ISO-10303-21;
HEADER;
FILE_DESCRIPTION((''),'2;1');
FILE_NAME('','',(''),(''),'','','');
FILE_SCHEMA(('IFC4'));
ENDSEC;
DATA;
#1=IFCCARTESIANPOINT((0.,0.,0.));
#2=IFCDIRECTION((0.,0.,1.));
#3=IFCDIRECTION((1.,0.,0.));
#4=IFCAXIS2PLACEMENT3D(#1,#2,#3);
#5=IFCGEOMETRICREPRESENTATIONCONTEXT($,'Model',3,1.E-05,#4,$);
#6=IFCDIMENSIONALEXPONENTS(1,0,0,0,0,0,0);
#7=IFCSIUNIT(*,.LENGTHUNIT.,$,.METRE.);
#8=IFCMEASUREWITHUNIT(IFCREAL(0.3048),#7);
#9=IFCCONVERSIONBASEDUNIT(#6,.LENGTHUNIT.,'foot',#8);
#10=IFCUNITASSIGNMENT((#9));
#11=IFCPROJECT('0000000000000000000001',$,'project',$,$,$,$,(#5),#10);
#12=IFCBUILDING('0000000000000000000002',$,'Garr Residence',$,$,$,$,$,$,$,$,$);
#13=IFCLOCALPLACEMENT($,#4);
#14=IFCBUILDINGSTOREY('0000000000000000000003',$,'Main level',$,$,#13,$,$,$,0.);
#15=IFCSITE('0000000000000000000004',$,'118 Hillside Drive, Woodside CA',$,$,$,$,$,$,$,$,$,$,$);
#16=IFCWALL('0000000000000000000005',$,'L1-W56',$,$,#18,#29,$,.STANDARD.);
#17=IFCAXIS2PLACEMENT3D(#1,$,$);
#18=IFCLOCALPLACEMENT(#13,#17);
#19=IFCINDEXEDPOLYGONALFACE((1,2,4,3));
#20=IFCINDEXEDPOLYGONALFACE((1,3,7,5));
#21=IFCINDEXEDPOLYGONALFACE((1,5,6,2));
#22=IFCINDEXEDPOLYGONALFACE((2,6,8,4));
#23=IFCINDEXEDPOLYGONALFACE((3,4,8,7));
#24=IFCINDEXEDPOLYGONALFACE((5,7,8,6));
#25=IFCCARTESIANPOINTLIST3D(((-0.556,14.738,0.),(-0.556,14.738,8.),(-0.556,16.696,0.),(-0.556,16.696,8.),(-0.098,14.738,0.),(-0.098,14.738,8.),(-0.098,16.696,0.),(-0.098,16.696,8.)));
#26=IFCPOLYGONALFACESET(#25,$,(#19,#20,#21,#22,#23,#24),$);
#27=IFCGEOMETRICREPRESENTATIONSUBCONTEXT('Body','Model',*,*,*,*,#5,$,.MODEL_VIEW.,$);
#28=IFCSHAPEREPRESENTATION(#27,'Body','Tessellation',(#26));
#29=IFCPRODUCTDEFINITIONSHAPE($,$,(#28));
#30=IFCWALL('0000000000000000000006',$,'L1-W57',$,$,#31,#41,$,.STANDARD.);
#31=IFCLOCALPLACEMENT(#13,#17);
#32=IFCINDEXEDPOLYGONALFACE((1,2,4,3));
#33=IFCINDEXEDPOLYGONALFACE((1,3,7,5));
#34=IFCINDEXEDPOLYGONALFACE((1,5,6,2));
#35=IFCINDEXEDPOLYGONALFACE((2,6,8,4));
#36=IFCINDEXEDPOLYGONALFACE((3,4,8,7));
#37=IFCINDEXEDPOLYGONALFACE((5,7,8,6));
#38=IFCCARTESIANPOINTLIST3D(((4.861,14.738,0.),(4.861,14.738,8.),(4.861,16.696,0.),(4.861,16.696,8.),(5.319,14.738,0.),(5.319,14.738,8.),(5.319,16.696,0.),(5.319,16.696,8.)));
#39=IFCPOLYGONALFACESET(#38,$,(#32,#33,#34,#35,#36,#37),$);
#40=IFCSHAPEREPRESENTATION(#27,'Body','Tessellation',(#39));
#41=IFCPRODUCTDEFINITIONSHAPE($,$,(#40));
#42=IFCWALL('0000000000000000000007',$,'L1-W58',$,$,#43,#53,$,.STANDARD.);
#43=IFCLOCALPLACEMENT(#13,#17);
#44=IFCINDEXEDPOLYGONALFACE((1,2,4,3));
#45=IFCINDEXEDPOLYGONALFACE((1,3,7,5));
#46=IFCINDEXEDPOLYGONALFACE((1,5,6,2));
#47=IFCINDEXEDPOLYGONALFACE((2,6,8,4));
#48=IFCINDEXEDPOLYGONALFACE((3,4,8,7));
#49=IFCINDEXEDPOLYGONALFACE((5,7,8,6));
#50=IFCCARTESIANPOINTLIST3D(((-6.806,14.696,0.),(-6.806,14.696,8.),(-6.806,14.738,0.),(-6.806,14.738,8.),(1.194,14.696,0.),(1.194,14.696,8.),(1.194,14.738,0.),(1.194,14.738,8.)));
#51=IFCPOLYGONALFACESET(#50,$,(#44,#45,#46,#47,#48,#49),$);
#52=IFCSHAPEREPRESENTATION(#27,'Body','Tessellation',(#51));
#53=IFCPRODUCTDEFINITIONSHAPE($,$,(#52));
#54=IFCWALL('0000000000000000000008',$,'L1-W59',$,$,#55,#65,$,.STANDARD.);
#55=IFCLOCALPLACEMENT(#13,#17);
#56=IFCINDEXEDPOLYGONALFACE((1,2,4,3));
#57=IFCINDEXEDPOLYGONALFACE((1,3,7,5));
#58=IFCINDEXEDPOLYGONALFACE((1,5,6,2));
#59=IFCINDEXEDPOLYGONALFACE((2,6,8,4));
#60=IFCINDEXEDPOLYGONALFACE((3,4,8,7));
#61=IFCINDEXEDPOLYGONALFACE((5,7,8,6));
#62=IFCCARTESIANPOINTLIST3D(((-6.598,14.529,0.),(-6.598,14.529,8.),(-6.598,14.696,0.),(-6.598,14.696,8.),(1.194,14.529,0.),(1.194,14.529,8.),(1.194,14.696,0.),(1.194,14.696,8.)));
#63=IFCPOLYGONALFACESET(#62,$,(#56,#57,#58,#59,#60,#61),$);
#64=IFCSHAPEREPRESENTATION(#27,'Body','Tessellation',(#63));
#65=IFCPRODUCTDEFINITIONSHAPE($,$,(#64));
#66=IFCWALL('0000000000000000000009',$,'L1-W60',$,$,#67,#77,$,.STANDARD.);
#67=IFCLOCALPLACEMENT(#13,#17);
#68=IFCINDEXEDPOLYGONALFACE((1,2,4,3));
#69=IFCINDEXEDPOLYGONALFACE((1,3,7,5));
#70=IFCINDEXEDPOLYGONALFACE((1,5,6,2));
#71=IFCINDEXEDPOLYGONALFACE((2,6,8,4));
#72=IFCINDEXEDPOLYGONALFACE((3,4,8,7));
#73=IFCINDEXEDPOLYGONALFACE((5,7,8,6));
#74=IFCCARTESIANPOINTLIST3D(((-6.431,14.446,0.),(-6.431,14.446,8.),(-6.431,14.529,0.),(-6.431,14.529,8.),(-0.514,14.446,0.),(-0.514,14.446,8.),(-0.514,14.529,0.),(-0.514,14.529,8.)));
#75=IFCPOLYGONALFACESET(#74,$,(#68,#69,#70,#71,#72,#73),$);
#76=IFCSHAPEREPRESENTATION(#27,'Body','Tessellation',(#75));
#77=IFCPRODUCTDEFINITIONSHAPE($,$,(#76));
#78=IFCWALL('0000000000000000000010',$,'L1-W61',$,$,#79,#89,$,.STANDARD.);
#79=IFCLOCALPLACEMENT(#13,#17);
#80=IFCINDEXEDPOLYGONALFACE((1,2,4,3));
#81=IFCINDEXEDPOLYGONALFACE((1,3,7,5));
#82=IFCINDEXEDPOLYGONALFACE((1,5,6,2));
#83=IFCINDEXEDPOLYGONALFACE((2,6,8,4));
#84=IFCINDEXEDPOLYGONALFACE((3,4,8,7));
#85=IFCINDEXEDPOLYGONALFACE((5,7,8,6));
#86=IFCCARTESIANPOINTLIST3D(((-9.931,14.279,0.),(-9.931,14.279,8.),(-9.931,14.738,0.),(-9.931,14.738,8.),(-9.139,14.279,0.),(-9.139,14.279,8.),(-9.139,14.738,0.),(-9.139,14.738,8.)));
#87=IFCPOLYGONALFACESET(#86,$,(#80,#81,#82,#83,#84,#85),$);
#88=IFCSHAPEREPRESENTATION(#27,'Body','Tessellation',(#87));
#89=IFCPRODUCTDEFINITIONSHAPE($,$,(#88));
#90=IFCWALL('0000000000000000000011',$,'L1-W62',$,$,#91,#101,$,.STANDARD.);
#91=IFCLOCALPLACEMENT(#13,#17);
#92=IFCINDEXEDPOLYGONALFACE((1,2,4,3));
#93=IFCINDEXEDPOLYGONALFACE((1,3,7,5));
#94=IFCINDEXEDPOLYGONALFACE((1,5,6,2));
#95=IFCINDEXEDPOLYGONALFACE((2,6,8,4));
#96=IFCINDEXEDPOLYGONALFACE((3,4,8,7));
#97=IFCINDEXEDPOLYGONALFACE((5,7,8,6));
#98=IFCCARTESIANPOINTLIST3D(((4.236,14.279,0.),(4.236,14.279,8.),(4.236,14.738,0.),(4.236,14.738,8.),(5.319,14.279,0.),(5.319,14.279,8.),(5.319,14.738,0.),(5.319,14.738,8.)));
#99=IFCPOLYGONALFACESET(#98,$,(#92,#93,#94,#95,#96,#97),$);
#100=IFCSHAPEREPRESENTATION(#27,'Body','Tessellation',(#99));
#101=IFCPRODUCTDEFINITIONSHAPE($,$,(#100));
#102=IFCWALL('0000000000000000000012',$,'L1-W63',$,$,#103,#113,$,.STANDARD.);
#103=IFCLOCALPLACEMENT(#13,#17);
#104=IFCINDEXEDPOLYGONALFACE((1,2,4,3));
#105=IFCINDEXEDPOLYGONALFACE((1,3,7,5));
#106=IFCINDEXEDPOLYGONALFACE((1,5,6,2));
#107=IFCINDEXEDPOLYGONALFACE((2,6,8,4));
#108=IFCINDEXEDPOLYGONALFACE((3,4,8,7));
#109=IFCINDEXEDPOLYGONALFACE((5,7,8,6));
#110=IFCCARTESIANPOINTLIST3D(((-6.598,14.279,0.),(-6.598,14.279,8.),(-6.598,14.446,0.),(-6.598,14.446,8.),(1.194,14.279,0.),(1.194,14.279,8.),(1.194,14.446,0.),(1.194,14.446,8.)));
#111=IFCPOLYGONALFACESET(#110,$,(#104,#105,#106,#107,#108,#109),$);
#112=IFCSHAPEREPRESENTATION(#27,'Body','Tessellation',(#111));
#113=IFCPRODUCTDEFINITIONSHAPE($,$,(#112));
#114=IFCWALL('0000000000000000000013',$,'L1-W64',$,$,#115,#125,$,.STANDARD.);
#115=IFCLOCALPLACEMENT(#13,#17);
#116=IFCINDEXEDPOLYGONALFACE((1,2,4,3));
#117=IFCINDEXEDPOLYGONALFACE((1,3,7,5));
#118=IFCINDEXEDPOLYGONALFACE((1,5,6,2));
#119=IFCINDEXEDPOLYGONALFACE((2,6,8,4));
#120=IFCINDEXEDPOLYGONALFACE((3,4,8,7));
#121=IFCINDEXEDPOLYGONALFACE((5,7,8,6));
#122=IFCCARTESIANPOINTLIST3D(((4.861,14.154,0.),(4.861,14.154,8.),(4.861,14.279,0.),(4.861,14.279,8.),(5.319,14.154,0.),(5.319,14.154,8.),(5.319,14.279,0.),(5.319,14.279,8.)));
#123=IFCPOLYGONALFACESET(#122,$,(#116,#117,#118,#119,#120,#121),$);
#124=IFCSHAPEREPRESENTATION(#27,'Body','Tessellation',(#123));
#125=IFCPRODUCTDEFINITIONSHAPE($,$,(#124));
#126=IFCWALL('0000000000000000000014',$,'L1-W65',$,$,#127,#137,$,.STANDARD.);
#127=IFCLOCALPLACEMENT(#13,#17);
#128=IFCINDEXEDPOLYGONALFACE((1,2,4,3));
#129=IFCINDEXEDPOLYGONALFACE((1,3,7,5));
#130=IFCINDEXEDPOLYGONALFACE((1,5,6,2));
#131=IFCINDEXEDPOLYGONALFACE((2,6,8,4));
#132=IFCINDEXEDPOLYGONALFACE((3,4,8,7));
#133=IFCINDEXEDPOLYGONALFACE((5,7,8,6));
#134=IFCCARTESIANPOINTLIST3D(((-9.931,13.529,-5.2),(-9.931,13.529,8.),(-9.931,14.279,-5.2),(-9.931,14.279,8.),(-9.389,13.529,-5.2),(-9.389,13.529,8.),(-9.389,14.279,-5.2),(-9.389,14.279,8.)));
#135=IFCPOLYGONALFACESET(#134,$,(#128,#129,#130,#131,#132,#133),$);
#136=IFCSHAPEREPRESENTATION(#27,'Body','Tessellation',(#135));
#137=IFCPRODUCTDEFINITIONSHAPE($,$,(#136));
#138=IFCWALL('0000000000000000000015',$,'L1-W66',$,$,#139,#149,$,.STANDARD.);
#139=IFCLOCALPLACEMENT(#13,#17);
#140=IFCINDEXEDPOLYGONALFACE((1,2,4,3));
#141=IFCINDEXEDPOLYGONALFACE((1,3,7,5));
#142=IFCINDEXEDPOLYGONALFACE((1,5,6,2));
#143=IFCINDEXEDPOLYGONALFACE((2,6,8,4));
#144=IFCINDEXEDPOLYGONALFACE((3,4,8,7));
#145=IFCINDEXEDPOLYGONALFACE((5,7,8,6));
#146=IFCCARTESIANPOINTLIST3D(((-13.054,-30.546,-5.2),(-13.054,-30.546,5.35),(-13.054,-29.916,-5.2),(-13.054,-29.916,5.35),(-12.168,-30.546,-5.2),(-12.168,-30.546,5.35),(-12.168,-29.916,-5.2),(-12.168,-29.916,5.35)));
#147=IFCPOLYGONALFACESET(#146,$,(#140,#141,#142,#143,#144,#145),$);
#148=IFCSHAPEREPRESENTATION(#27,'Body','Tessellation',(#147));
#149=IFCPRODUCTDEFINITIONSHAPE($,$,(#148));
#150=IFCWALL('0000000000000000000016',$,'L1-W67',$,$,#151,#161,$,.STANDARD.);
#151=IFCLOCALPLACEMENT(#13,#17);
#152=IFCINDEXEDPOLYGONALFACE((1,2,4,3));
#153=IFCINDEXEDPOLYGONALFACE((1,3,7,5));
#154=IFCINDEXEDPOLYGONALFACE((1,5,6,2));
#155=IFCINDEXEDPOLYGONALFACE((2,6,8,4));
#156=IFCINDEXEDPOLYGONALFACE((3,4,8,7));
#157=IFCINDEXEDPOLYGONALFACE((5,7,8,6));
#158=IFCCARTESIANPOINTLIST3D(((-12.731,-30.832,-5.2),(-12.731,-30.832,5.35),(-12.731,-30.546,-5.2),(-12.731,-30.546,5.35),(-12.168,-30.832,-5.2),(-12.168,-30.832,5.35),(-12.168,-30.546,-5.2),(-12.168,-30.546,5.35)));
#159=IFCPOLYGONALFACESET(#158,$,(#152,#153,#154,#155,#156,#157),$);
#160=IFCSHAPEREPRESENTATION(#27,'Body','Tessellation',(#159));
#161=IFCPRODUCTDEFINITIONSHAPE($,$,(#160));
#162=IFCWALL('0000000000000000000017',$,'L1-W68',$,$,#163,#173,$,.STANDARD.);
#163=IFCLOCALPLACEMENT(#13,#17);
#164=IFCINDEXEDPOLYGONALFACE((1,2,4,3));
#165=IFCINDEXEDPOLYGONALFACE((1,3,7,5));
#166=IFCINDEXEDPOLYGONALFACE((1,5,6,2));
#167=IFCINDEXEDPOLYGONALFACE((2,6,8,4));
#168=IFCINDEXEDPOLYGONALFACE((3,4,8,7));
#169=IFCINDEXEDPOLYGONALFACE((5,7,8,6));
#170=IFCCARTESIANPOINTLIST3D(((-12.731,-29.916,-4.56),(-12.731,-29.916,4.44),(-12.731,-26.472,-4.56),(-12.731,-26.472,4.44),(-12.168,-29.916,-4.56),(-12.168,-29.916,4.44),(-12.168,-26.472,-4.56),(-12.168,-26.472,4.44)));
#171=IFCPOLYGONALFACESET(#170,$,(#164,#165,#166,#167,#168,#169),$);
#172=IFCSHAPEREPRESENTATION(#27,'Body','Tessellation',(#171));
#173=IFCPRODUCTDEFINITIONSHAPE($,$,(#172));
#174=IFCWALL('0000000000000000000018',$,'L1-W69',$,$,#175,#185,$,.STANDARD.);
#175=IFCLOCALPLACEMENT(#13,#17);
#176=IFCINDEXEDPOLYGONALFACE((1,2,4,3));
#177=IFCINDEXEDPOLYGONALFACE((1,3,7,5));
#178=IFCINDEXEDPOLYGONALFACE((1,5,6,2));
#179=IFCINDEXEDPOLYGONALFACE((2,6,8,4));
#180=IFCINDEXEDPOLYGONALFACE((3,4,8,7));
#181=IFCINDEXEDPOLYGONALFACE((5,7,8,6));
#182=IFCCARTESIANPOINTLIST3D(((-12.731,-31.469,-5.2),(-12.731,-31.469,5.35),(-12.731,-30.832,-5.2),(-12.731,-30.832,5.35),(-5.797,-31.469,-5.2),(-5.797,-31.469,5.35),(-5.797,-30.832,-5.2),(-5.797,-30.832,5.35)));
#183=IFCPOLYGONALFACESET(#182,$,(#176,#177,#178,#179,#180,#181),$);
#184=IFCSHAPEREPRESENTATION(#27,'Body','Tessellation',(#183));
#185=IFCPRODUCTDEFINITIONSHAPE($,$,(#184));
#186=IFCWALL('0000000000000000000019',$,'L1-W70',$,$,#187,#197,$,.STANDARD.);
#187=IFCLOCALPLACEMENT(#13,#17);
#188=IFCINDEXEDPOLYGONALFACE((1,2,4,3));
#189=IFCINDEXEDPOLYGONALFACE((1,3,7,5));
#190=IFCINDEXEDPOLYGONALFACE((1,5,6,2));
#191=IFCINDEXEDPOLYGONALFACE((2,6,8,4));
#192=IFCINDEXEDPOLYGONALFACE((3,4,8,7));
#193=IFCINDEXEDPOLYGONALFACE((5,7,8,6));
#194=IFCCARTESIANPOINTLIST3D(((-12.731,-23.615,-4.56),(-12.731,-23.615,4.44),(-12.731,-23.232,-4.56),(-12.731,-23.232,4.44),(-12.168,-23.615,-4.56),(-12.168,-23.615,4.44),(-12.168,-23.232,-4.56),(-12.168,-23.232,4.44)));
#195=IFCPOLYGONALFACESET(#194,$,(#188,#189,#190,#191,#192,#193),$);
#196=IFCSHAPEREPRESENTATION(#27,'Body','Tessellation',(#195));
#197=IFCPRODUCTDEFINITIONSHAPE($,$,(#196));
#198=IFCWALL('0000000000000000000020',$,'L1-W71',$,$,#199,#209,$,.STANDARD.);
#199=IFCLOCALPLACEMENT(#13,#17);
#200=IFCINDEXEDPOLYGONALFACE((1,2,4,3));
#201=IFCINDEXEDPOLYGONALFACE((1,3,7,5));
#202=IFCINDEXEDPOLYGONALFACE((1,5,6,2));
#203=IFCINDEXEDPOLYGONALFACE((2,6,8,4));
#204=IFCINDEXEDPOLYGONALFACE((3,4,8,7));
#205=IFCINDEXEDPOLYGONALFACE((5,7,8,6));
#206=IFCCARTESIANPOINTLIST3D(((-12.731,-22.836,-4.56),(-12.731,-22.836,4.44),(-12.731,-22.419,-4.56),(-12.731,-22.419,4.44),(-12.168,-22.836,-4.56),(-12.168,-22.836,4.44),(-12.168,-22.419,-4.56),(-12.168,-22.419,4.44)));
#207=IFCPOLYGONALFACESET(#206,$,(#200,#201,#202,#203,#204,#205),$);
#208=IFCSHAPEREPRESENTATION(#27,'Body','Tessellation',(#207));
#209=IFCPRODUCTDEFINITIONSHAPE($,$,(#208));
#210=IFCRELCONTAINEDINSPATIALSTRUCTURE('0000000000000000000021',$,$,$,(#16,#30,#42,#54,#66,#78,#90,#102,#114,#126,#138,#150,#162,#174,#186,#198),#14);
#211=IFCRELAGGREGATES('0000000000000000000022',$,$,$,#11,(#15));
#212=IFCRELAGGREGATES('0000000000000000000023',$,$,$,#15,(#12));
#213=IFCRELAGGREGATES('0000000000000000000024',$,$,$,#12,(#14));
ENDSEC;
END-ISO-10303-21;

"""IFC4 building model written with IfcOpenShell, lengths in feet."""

from ifc_helpers import new_model, entity, si_unit, converted_unit, frame, origin, origin_with_axes, place, context, subcontext, project, spatial, polyline, outline, extrude, element, save


model = new_model("IFC4")

# Units and contexts
model_context = context("Model", 3, precision=1e-05, world=origin_with_axes())
body_context = subcontext(model_context, "Body", "Model", "MODEL_VIEW")
ifc_project = project(units=[converted_unit("LENGTHUNIT", "foot", entity("IfcReal", 0.3048), si_unit("LENGTHUNIT", "METRE"), dimensions=[1, 0, 0, 0, 0, 0, 0])], contexts=[model_context])

# Site, building, storey
site = spatial("IfcSite", under=ifc_project, Name="118 Hillside Drive, Woodside CA")
building = spatial("IfcBuilding", under=site, Name="Garr Residence")
storey_placement = place(None, origin_with_axes())
storey = spatial("IfcBuildingStorey", under=building, at=storey_placement, Name="Main level", Elevation=0.0)

# Walls
wall_1_placement = place(storey_placement, origin_with_axes())
element("IfcWall", 1, at=wall_1_placement, inside=storey, Name="L1-W56", PredefinedType="STANDARD", context=body_context, shape_type="SweptSolid", body=[
    extrude(outline(polyline([(-0.098, 14.738), (-0.098, 16.696), (-0.556, 16.696), (-0.556, 14.738), (-0.098, 14.738)])), origin(), (0.0, 0.0, 1.0), 8.0),
])
wall_2_placement = place(storey_placement, origin_with_axes())
element("IfcWall", 2, at=wall_2_placement, inside=storey, Name="L1-W57", PredefinedType="STANDARD", context=body_context, shape_type="SweptSolid", body=[
    extrude(outline(polyline([(5.319, 14.738), (5.319, 16.696), (4.861, 16.696), (4.861, 14.738), (5.319, 14.738)])), origin(), (0.0, 0.0, 1.0), 8.0),
])
wall_3_placement = place(storey_placement, origin_with_axes())
element("IfcWall", 3, at=wall_3_placement, inside=storey, Name="L1-W58", PredefinedType="STANDARD", context=body_context, shape_type="SweptSolid", body=[
    extrude(outline(polyline([(1.194, 14.696), (1.194, 14.738), (-6.806, 14.738), (-6.806, 14.696), (1.194, 14.696)])), origin(), (0.0, 0.0, 1.0), 8.0),
])
wall_4_placement = place(storey_placement, origin_with_axes())
element("IfcWall", 4, at=wall_4_placement, inside=storey, Name="L1-W59", PredefinedType="STANDARD", context=body_context, shape_type="SweptSolid", body=[
    extrude(outline(polyline([(1.194, 14.529), (1.194, 14.696), (-6.598, 14.696), (-6.598, 14.529), (1.194, 14.529)])), origin(), (0.0, 0.0, 1.0), 8.0),
])
wall_5_placement = place(storey_placement, origin_with_axes())
element("IfcWall", 5, at=wall_5_placement, inside=storey, Name="L1-W60", PredefinedType="STANDARD", context=body_context, shape_type="SweptSolid", body=[
    extrude(outline(polyline([(-0.514, 14.446), (-0.514, 14.529), (-6.431, 14.529), (-6.431, 14.446), (-0.514, 14.446)])), origin(), (0.0, 0.0, 1.0), 8.0),
])
wall_6_placement = place(storey_placement, origin_with_axes())
element("IfcWall", 6, at=wall_6_placement, inside=storey, Name="L1-W61", PredefinedType="STANDARD", context=body_context, shape_type="SweptSolid", body=[
    extrude(outline(polyline([(-9.139, 14.279), (-9.139, 14.738), (-9.931, 14.738), (-9.931, 14.279), (-9.139, 14.279)])), origin(), (0.0, 0.0, 1.0), 8.0),
])
wall_7_placement = place(storey_placement, origin_with_axes())
element("IfcWall", 7, at=wall_7_placement, inside=storey, Name="L1-W62", PredefinedType="STANDARD", context=body_context, shape_type="SweptSolid", body=[
    extrude(outline(polyline([(5.319, 14.279), (5.319, 14.738), (4.236, 14.738), (4.236, 14.279), (5.319, 14.279)])), origin(), (0.0, 0.0, 1.0), 8.0),
])
wall_8_placement = place(storey_placement, origin_with_axes())
element("IfcWall", 8, at=wall_8_placement, inside=storey, Name="L1-W63", PredefinedType="STANDARD", context=body_context, shape_type="SweptSolid", body=[
    extrude(outline(polyline([(1.194, 14.279), (1.194, 14.446), (-6.598, 14.446), (-6.598, 14.279), (1.194, 14.279)])), origin(), (0.0, 0.0, 1.0), 8.0),
])
wall_9_placement = place(storey_placement, origin_with_axes())
element("IfcWall", 9, at=wall_9_placement, inside=storey, Name="L1-W64", PredefinedType="STANDARD", context=body_context, shape_type="SweptSolid", body=[
    extrude(outline(polyline([(5.319, 14.154), (5.319, 14.279), (4.861, 14.279), (4.861, 14.154), (5.319, 14.154)])), origin(), (0.0, 0.0, 1.0), 8.0),
])
wall_10_placement = place(storey_placement, frame((0.0, 0.0, -5.2), z_axis=(0.0, 0.0, 1.0), x_axis=(1.0, 0.0, 0.0)))
element("IfcWall", 10, at=wall_10_placement, inside=storey, Name="L1-W65", PredefinedType="STANDARD", context=body_context, shape_type="SweptSolid", body=[
    extrude(outline(polyline([(-9.389, 13.529), (-9.389, 14.279), (-9.931, 14.279), (-9.931, 13.529), (-9.389, 13.529)])), origin(), (0.0, 0.0, 1.0), 13.2),
])
wall_11_placement = place(storey_placement, frame((0.0, 0.0, -5.2), z_axis=(0.0, 0.0, 1.0), x_axis=(1.0, 0.0, 0.0)))
element("IfcWall", 11, at=wall_11_placement, inside=storey, Name="L1-W66", PredefinedType="STANDARD", context=body_context, shape_type="SweptSolid", body=[
    extrude(outline(polyline([(-12.168, -30.546), (-12.168, -29.916), (-13.054, -29.916), (-13.054, -30.546), (-12.168, -30.546)])), origin(), (0.0, 0.0, 1.0), 10.55),
])
wall_12_placement = place(storey_placement, frame((0.0, 0.0, -5.2), z_axis=(0.0, 0.0, 1.0), x_axis=(1.0, 0.0, 0.0)))
element("IfcWall", 12, at=wall_12_placement, inside=storey, Name="L1-W67", PredefinedType="STANDARD", context=body_context, shape_type="SweptSolid", body=[
    extrude(outline(polyline([(-12.168, -30.832), (-12.168, -30.546), (-12.731, -30.546), (-12.731, -30.832), (-12.168, -30.832)])), origin(), (0.0, 0.0, 1.0), 10.55),
])
wall_13_placement = place(storey_placement, frame((0.0, 0.0, -4.56), z_axis=(0.0, 0.0, 1.0), x_axis=(1.0, 0.0, 0.0)))
element("IfcWall", 13, at=wall_13_placement, inside=storey, Name="L1-W68", PredefinedType="STANDARD", context=body_context, shape_type="SweptSolid", body=[
    extrude(outline(polyline([(-12.168, -29.916), (-12.168, -26.472), (-12.731, -26.472), (-12.731, -29.916), (-12.168, -29.916)])), origin(), (0.0, 0.0, 1.0), 9.0),
])
wall_14_placement = place(storey_placement, frame((0.0, 0.0, -5.2), z_axis=(0.0, 0.0, 1.0), x_axis=(1.0, 0.0, 0.0)))
element("IfcWall", 14, at=wall_14_placement, inside=storey, Name="L1-W69", PredefinedType="STANDARD", context=body_context, shape_type="SweptSolid", body=[
    extrude(outline(polyline([(-5.797, -31.469), (-5.797, -30.832), (-12.731, -30.832), (-12.731, -31.469), (-5.797, -31.469)])), origin(), (0.0, 0.0, 1.0), 10.55),
])
wall_15_placement = place(storey_placement, frame((0.0, 0.0, -4.56), z_axis=(0.0, 0.0, 1.0), x_axis=(1.0, 0.0, 0.0)))
element("IfcWall", 15, at=wall_15_placement, inside=storey, Name="L1-W70", PredefinedType="STANDARD", context=body_context, shape_type="SweptSolid", body=[
    extrude(outline(polyline([(-12.168, -23.615), (-12.168, -23.232), (-12.731, -23.232), (-12.731, -23.615), (-12.168, -23.615)])), origin(), (0.0, 0.0, 1.0), 9.0),
])
wall_16_placement = place(storey_placement, frame((0.0, 0.0, -4.56), z_axis=(0.0, 0.0, 1.0), x_axis=(1.0, 0.0, 0.0)))
element("IfcWall", 16, at=wall_16_placement, inside=storey, Name="L1-W71", PredefinedType="STANDARD", context=body_context, shape_type="SweptSolid", body=[
    extrude(outline(polyline([(-12.168, -22.836), (-12.168, -22.419), (-12.731, -22.419), (-12.731, -22.836), (-12.168, -22.836)])), origin(), (0.0, 0.0, 1.0), 9.0),
])

save(model, "model.ifc")
